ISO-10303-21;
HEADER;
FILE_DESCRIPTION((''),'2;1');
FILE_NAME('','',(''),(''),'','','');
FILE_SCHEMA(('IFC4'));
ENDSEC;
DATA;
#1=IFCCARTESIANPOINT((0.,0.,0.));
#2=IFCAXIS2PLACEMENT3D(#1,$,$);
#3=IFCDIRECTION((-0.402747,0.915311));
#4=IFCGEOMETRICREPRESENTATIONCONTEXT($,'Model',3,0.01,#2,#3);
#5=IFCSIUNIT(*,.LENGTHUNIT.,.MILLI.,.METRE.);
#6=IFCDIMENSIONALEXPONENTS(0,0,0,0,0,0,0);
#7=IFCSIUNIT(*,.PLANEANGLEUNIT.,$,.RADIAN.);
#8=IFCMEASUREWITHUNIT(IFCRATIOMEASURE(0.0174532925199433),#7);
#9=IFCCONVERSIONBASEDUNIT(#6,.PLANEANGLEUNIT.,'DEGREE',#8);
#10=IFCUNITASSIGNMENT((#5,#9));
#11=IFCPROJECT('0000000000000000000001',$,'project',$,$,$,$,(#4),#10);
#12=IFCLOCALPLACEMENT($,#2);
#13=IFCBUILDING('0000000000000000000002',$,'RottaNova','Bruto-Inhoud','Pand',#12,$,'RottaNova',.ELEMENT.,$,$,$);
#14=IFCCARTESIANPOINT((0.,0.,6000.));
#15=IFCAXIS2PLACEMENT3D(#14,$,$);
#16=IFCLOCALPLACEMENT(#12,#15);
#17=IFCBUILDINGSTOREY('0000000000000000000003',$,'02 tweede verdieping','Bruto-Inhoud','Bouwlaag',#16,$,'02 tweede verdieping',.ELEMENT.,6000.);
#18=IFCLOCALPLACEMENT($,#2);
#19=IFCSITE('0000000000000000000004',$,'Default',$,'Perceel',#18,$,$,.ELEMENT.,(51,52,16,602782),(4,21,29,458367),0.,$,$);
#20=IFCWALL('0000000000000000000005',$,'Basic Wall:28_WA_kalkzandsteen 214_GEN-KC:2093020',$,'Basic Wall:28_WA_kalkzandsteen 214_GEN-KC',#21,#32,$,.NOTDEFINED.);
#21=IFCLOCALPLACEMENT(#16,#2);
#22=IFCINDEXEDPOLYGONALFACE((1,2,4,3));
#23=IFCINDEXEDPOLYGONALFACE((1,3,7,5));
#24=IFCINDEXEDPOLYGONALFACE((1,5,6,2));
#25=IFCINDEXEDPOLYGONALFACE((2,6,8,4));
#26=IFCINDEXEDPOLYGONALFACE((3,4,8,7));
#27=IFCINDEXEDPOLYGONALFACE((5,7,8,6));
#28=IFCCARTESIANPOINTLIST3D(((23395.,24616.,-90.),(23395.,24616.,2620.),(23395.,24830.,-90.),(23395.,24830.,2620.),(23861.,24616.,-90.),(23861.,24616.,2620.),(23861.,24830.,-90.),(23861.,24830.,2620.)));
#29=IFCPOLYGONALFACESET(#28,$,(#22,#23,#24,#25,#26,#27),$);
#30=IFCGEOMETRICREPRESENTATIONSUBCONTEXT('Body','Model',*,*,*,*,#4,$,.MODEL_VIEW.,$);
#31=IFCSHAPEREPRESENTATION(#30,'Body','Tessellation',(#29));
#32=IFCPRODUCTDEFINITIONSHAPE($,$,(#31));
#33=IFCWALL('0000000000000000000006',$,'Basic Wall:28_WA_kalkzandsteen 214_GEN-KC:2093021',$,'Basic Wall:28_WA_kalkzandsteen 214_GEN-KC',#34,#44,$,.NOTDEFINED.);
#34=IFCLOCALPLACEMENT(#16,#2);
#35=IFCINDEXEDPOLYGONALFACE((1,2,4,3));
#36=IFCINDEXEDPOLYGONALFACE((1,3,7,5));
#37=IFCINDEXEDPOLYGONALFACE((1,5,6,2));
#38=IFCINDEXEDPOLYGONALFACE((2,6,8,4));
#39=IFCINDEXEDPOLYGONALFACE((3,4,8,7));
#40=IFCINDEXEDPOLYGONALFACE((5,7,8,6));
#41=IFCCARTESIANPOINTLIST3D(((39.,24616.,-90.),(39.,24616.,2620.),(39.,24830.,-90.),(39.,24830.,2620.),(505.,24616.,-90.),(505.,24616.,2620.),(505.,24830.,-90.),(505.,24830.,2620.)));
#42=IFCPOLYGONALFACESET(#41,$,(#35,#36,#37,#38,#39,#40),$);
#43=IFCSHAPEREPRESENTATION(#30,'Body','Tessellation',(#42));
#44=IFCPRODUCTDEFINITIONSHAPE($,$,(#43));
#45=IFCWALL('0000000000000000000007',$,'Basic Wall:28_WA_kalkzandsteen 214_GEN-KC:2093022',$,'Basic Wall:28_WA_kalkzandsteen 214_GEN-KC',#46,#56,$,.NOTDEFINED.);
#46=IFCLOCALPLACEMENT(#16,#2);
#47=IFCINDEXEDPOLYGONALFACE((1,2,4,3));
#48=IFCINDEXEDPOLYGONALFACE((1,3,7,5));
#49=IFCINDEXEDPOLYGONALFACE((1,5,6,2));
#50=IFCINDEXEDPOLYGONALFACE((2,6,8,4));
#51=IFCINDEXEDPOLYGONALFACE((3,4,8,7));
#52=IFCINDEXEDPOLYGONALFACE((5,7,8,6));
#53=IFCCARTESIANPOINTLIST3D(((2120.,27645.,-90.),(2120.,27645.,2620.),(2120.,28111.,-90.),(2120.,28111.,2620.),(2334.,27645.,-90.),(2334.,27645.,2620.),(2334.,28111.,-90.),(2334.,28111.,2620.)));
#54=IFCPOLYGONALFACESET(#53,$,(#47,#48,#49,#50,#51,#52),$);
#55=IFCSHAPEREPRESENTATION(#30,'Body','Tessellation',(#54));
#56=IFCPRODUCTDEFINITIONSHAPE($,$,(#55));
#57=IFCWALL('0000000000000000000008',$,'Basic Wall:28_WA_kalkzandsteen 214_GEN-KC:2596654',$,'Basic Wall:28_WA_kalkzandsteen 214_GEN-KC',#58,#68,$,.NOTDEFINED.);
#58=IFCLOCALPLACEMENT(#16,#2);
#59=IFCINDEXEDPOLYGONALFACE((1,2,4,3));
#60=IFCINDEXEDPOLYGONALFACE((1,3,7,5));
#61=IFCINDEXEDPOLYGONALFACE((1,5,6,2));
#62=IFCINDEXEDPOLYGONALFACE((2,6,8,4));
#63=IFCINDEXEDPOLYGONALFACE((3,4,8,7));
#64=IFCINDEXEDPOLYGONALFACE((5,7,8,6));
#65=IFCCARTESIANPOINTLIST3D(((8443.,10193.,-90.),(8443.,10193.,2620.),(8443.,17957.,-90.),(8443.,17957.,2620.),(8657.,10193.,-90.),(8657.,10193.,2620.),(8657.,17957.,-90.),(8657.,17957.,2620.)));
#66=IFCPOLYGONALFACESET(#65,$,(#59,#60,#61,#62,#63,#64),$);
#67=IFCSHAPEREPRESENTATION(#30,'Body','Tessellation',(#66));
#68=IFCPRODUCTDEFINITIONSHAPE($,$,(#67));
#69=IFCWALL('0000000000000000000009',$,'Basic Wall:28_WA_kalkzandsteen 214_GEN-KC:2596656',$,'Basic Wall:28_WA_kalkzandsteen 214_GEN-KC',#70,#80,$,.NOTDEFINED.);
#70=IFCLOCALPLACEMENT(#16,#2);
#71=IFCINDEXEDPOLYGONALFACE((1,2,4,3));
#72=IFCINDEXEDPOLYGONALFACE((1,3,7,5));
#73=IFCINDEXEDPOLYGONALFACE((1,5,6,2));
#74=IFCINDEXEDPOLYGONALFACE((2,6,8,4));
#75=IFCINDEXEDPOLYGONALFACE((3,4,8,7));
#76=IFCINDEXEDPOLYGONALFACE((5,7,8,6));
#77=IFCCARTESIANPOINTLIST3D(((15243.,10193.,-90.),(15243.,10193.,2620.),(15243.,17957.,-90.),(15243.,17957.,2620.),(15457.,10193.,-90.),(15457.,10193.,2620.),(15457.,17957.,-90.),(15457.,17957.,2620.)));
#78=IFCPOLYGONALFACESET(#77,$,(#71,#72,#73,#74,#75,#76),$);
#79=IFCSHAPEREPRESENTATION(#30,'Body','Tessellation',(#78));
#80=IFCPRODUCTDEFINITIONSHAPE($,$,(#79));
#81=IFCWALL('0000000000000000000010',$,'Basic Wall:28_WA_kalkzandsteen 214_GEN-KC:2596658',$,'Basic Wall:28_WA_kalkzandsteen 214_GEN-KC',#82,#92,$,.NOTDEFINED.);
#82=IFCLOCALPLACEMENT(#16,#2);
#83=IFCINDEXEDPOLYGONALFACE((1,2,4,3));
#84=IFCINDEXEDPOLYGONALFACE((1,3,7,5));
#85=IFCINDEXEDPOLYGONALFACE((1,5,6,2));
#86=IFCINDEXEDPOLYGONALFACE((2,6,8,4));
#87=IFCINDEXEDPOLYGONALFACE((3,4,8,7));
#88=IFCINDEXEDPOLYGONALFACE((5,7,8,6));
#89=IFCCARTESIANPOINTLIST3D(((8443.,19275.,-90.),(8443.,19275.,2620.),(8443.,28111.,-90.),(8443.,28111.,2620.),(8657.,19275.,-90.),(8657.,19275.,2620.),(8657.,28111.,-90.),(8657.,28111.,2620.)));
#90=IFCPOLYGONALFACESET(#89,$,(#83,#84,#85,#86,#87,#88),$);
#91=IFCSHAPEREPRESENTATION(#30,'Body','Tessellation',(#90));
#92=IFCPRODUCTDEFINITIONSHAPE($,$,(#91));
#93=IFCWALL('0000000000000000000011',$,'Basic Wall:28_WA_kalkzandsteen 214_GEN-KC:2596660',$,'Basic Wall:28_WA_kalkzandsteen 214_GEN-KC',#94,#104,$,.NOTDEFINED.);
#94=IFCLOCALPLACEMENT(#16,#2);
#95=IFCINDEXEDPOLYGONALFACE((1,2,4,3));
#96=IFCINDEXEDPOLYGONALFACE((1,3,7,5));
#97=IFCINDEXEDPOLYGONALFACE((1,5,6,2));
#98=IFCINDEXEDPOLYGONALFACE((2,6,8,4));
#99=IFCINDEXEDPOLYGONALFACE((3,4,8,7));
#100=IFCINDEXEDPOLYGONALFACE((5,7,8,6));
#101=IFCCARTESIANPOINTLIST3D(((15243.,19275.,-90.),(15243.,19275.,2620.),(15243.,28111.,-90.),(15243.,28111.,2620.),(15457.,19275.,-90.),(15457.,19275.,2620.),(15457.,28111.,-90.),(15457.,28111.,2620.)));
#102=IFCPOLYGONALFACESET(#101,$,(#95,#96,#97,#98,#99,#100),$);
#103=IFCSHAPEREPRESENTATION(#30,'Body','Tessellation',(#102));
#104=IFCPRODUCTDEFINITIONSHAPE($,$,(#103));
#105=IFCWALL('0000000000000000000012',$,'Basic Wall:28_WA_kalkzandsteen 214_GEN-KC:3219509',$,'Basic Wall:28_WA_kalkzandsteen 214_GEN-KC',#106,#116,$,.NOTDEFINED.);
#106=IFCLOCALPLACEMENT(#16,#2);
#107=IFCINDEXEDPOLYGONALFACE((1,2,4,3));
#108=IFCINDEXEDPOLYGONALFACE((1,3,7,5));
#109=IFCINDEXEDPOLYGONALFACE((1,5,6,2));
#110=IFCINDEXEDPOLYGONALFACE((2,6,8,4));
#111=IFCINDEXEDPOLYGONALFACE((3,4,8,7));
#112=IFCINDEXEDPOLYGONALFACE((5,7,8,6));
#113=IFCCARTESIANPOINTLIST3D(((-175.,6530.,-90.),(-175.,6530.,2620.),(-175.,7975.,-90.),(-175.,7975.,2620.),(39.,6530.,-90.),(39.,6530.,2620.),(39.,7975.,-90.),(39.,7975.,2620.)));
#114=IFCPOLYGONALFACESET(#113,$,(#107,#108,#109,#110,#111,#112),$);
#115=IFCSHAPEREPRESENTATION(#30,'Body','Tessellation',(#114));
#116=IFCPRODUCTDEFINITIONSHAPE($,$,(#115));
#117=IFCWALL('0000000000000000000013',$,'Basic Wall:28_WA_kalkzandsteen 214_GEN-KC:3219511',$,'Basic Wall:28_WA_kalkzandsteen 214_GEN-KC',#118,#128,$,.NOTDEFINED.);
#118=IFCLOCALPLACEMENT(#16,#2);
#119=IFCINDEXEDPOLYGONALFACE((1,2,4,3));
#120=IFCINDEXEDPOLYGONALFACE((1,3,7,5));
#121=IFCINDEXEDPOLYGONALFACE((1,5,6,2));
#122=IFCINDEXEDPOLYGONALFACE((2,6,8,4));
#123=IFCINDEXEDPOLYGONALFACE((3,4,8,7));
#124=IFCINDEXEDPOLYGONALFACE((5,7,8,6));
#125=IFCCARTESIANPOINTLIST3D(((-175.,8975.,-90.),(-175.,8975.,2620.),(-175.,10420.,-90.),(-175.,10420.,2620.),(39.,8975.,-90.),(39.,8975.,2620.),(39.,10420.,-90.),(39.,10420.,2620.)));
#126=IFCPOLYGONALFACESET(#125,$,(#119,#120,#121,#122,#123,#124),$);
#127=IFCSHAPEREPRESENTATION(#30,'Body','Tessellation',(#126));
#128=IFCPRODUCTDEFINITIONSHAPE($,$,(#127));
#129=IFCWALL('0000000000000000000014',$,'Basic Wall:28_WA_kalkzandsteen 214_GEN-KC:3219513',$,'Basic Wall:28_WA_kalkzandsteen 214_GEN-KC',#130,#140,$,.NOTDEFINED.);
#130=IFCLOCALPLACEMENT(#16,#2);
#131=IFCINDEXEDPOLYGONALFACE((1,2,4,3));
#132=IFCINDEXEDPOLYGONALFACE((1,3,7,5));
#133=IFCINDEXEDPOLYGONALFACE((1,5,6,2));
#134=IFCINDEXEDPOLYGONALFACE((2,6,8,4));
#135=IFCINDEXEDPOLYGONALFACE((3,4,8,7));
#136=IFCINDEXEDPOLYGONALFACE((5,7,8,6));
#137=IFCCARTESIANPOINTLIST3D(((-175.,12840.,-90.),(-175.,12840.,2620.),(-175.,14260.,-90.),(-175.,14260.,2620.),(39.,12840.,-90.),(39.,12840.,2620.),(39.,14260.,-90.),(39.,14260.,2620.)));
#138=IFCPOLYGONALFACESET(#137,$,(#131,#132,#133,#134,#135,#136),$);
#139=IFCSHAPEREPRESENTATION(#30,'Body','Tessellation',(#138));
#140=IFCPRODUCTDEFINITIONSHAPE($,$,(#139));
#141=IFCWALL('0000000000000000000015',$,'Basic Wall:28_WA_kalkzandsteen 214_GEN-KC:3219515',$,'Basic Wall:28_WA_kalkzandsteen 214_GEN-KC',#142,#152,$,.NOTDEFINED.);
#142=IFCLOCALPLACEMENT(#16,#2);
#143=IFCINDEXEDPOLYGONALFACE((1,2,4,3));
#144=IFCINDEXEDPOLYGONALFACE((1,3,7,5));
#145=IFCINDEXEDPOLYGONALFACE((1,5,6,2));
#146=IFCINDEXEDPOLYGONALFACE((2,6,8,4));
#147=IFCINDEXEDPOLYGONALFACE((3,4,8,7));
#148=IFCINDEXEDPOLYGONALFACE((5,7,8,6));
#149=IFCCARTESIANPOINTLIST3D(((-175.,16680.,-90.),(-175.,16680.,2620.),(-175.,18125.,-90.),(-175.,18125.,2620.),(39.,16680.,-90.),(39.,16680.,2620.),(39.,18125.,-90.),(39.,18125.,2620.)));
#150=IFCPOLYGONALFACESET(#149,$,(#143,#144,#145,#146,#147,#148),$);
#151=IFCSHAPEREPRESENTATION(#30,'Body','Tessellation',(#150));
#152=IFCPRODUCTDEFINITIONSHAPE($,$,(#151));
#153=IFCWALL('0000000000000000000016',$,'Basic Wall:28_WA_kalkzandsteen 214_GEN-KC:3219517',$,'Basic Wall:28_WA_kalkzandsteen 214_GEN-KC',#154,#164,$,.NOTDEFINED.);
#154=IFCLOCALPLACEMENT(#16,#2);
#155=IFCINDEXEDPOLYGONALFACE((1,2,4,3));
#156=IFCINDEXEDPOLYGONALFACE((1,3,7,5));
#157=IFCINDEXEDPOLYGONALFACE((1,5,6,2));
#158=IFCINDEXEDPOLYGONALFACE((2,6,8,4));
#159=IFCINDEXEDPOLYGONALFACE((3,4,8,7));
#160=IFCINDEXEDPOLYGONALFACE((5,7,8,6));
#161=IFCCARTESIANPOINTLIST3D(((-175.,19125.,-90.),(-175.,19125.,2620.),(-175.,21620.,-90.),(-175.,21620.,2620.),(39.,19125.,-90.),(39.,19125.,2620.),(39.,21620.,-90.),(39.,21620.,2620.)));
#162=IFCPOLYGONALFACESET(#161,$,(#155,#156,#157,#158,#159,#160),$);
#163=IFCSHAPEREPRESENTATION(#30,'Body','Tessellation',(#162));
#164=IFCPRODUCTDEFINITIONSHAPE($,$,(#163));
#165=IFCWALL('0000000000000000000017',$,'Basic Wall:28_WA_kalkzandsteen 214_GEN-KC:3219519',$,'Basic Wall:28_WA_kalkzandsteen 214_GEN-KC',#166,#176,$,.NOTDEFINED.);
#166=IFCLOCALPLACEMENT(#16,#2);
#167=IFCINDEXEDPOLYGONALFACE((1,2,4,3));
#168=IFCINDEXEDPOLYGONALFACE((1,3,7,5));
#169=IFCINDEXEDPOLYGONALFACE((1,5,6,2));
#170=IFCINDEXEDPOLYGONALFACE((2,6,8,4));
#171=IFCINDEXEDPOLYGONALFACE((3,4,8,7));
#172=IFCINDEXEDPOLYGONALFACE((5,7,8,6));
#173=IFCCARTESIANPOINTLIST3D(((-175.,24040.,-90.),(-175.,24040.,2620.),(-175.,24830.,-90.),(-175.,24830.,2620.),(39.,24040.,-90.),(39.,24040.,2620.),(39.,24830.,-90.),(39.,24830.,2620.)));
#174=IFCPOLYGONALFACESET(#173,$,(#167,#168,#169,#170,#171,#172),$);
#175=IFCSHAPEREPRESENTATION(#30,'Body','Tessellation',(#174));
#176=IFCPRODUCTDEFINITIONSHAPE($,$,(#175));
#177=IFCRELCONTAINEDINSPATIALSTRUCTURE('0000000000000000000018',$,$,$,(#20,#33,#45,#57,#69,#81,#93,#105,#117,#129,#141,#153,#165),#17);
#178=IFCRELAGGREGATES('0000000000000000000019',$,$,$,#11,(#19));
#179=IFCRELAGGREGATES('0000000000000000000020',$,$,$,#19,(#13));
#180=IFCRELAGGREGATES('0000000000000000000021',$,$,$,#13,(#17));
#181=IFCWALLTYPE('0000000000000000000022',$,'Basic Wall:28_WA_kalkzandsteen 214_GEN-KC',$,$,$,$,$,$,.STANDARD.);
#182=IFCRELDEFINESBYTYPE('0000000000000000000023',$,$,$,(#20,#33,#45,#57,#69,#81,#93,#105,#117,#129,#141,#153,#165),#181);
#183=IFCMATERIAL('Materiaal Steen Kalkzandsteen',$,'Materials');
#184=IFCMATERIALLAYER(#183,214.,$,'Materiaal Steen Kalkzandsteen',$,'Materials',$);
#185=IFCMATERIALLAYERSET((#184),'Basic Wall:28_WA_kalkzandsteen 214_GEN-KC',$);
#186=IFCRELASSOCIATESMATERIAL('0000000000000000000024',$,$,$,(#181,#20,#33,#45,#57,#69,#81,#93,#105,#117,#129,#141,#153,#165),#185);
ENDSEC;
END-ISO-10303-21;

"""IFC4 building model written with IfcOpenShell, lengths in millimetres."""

from ifc_helpers import new_model, entity, si_unit, converted_unit, direction, frame, frame_2d, origin, place, context, subcontext, project, spatial, rectangle, extrude, material, layer, layer_set, type_object, element, save


model = new_model("IFC4")

# Units and contexts
model_context = context("Model", 3, precision=0.01, world=origin(), true_north=direction((-0.402747, 0.915311)))
body_context = subcontext(model_context, "Body", "Model", "MODEL_VIEW")
ifc_project = project(units=[si_unit("LENGTHUNIT", "METRE", prefix="MILLI"), converted_unit("PLANEANGLEUNIT", "DEGREE", entity("IfcRatioMeasure", 0.0174532925199433), si_unit("PLANEANGLEUNIT", "RADIAN"), dimensions=[0, 0, 0, 0, 0, 0, 0])], contexts=[model_context])

# Site, building, storey
site_placement = place(None, origin())
site = spatial("IfcSite", under=ifc_project, at=site_placement, Name="Default", ObjectType="Perceel", CompositionType="ELEMENT", RefLatitude=(51, 52, 16, 602782), RefLongitude=(4, 21, 29, 458367), RefElevation=0.0)
building_placement = place(None, origin())
building = spatial("IfcBuilding", under=site, at=building_placement, Name="RottaNova", Description="Bruto-Inhoud", ObjectType="Pand", LongName="RottaNova", CompositionType="ELEMENT")
storey_placement = place(building_placement, frame((0.0, 0.0, 6000.0)))
storey = spatial("IfcBuildingStorey", under=building, at=storey_placement, Name="02 tweede verdieping", Description="Bruto-Inhoud", ObjectType="Bouwlaag", LongName="02 tweede verdieping", CompositionType="ELEMENT", Elevation=6000.0)

# Walls
ifc_material_1 = material(Name="Materiaal Steen Kalkzandsteen", Category="Materials")
ifc_layer_1 = layer(ifc_material_1, 214.0, Name="Materiaal Steen Kalkzandsteen", Category="Materials")
ifc_layer_set_1 = layer_set([ifc_layer_1], Name="Basic Wall:28_WA_kalkzandsteen 214_GEN-KC")
wall_type_1 = type_object("IfcWallType", Name="Basic Wall:28_WA_kalkzandsteen 214_GEN-KC", PredefinedType="STANDARD", material=ifc_layer_set_1)
wall_1_placement = place(storey_placement, frame((23395.0, 24723.0, -90.0)))
element("IfcWall", 1, at=wall_1_placement, inside=storey, type_object=wall_type_1, material=ifc_layer_set_1, Name="Basic Wall:28_WA_kalkzandsteen 214_GEN-KC:2093020", ObjectType="Basic Wall:28_WA_kalkzandsteen 214_GEN-KC", PredefinedType="NOTDEFINED", context=body_context, shape_type="SweptSolid", body=[
    extrude(rectangle(XDim=466.0, YDim=214.0, at=frame_2d((233.0, 0.0), x_axis=(-1.0, 0.0))), origin(), (0.0, 0.0, 1.0), 2710.0),
])
wall_2_placement = place(storey_placement, frame((39.0, 24723.0, -90.0)))
element("IfcWall", 2, at=wall_2_placement, inside=storey, type_object=wall_type_1, material=ifc_layer_set_1, Name="Basic Wall:28_WA_kalkzandsteen 214_GEN-KC:2093021", ObjectType="Basic Wall:28_WA_kalkzandsteen 214_GEN-KC", PredefinedType="NOTDEFINED", context=body_context, shape_type="SweptSolid", body=[
    extrude(rectangle(XDim=466.0, YDim=214.0, at=frame_2d((233.0, 0.0), x_axis=(-1.0, 0.0))), origin(), (0.0, 0.0, 1.0), 2710.0),
])
wall_3_placement = place(storey_placement, frame((2227.0, 28111.0, -90.0), z_axis=(0.0, 0.0, 1.0), x_axis=(0.0, -1.0, 0.0)))
element("IfcWall", 3, at=wall_3_placement, inside=storey, type_object=wall_type_1, material=ifc_layer_set_1, Name="Basic Wall:28_WA_kalkzandsteen 214_GEN-KC:2093022", ObjectType="Basic Wall:28_WA_kalkzandsteen 214_GEN-KC", PredefinedType="NOTDEFINED", context=body_context, shape_type="SweptSolid", body=[
    extrude(rectangle(XDim=466.0, YDim=214.0, at=frame_2d((233.0, 0.0), x_axis=(-1.0, 0.0))), origin(), (0.0, 0.0, 1.0), 2710.0),
])
wall_4_placement = place(storey_placement, frame((8550.0, 10193.0, -90.0), z_axis=(0.0, 0.0, 1.0), x_axis=(0.0, 1.0, 0.0)))
element("IfcWall", 4, at=wall_4_placement, inside=storey, type_object=wall_type_1, material=ifc_layer_set_1, Name="Basic Wall:28_WA_kalkzandsteen 214_GEN-KC:2596654", ObjectType="Basic Wall:28_WA_kalkzandsteen 214_GEN-KC", PredefinedType="NOTDEFINED", context=body_context, shape_type="SweptSolid", body=[
    extrude(rectangle(XDim=7764.0, YDim=214.0, at=frame_2d((3882.0, 0.0), x_axis=(1.0, 0.0))), origin(), (0.0, 0.0, 1.0), 2710.0),
])
wall_5_placement = place(storey_placement, frame((15350.0, 10193.0, -90.0), z_axis=(0.0, 0.0, 1.0), x_axis=(0.0, 1.0, 0.0)))
element("IfcWall", 5, at=wall_5_placement, inside=storey, type_object=wall_type_1, material=ifc_layer_set_1, Name="Basic Wall:28_WA_kalkzandsteen 214_GEN-KC:2596656", ObjectType="Basic Wall:28_WA_kalkzandsteen 214_GEN-KC", PredefinedType="NOTDEFINED", context=body_context, shape_type="SweptSolid", body=[
    extrude(rectangle(XDim=7764.0, YDim=214.0, at=frame_2d((3882.0, 0.0), x_axis=(1.0, 0.0))), origin(), (0.0, 0.0, 1.0), 2710.0),
])
wall_6_placement = place(storey_placement, frame((8550.0, 19275.0, -90.0), z_axis=(0.0, 0.0, 1.0), x_axis=(0.0, 1.0, 0.0)))
element("IfcWall", 6, at=wall_6_placement, inside=storey, type_object=wall_type_1, material=ifc_layer_set_1, Name="Basic Wall:28_WA_kalkzandsteen 214_GEN-KC:2596658", ObjectType="Basic Wall:28_WA_kalkzandsteen 214_GEN-KC", PredefinedType="NOTDEFINED", context=body_context, shape_type="SweptSolid", body=[
    extrude(rectangle(XDim=8836.0, YDim=214.0, at=frame_2d((0.0, 0.0), x_axis=(1.0, 0.0))), frame((4418.0, 0.0, 0.0), z_axis=(0.0, 0.0, 1.0), x_axis=(-1.0, 0.0, 0.0)), (0.0, 0.0, 1.0), 2710.0),
])
wall_7_placement = place(storey_placement, frame((15350.0, 19275.0, -90.0), z_axis=(0.0, 0.0, 1.0), x_axis=(0.0, 1.0, 0.0)))
element("IfcWall", 7, at=wall_7_placement, inside=storey, type_object=wall_type_1, material=ifc_layer_set_1, Name="Basic Wall:28_WA_kalkzandsteen 214_GEN-KC:2596660", ObjectType="Basic Wall:28_WA_kalkzandsteen 214_GEN-KC", PredefinedType="NOTDEFINED", context=body_context, shape_type="SweptSolid", body=[
    extrude(rectangle(XDim=8836.0, YDim=214.0, at=frame_2d((0.0, 0.0), x_axis=(1.0, 0.0))), frame((4418.0, 0.0, 0.0), z_axis=(0.0, 0.0, 1.0), x_axis=(-1.0, 0.0, 0.0)), (0.0, 0.0, 1.0), 2710.0),
])
wall_8_placement = place(storey_placement, frame((-68.0, 6530.0, -90.0), z_axis=(0.0, 0.0, 1.0), x_axis=(0.0, 1.0, 0.0)))
element("IfcWall", 8, at=wall_8_placement, inside=storey, type_object=wall_type_1, material=ifc_layer_set_1, Name="Basic Wall:28_WA_kalkzandsteen 214_GEN-KC:3219509", ObjectType="Basic Wall:28_WA_kalkzandsteen 214_GEN-KC", PredefinedType="NOTDEFINED", context=body_context, shape_type="SweptSolid", body=[
    extrude(rectangle(XDim=1445.0, YDim=214.0, at=frame_2d((722.5, 0.0), x_axis=(-1.0, 0.0))), origin(), (0.0, 0.0, 1.0), 2710.0),
])
wall_9_placement = place(storey_placement, frame((-68.0, 8975.0, -90.0), z_axis=(0.0, 0.0, 1.0), x_axis=(0.0, 1.0, 0.0)))
element("IfcWall", 9, at=wall_9_placement, inside=storey, type_object=wall_type_1, material=ifc_layer_set_1, Name="Basic Wall:28_WA_kalkzandsteen 214_GEN-KC:3219511", ObjectType="Basic Wall:28_WA_kalkzandsteen 214_GEN-KC", PredefinedType="NOTDEFINED", context=body_context, shape_type="SweptSolid", body=[
    extrude(rectangle(XDim=1445.0, YDim=214.0, at=frame_2d((722.5, 0.0), x_axis=(-1.0, 0.0))), origin(), (0.0, 0.0, 1.0), 2710.0),
])
wall_10_placement = place(storey_placement, frame((-68.0, 12840.0, -90.0), z_axis=(0.0, 0.0, 1.0), x_axis=(0.0, 1.0, 0.0)))
element("IfcWall", 10, at=wall_10_placement, inside=storey, type_object=wall_type_1, material=ifc_layer_set_1, Name="Basic Wall:28_WA_kalkzandsteen 214_GEN-KC:3219513", ObjectType="Basic Wall:28_WA_kalkzandsteen 214_GEN-KC", PredefinedType="NOTDEFINED", context=body_context, shape_type="SweptSolid", body=[
    extrude(rectangle(XDim=1420.0, YDim=214.0, at=frame_2d((710.0, 0.0), x_axis=(-1.0, 0.0))), origin(), (0.0, 0.0, 1.0), 2710.0),
])
wall_11_placement = place(storey_placement, frame((-68.0, 16680.0, -90.0), z_axis=(0.0, 0.0, 1.0), x_axis=(0.0, 1.0, 0.0)))
element("IfcWall", 11, at=wall_11_placement, inside=storey, type_object=wall_type_1, material=ifc_layer_set_1, Name="Basic Wall:28_WA_kalkzandsteen 214_GEN-KC:3219515", ObjectType="Basic Wall:28_WA_kalkzandsteen 214_GEN-KC", PredefinedType="NOTDEFINED", context=body_context, shape_type="SweptSolid", body=[
    extrude(rectangle(XDim=1445.0, YDim=214.0, at=frame_2d((722.5, 0.0), x_axis=(-1.0, 0.0))), origin(), (0.0, 0.0, 1.0), 2710.0),
])
wall_12_placement = place(storey_placement, frame((-68.0, 19125.0, -90.0), z_axis=(0.0, 0.0, 1.0), x_axis=(0.0, 1.0, 0.0)))
element("IfcWall", 12, at=wall_12_placement, inside=storey, type_object=wall_type_1, material=ifc_layer_set_1, Name="Basic Wall:28_WA_kalkzandsteen 214_GEN-KC:3219517", ObjectType="Basic Wall:28_WA_kalkzandsteen 214_GEN-KC", PredefinedType="NOTDEFINED", context=body_context, shape_type="SweptSolid", body=[
    extrude(rectangle(XDim=2495.0, YDim=214.0, at=frame_2d((1247.5, 0.0), x_axis=(-1.0, 0.0))), origin(), (0.0, 0.0, 1.0), 2710.0),
])
wall_13_placement = place(storey_placement, frame((-68.0, 24040.0, -90.0), z_axis=(0.0, 0.0, 1.0), x_axis=(0.0, 1.0, 0.0)))
element("IfcWall", 13, at=wall_13_placement, inside=storey, type_object=wall_type_1, material=ifc_layer_set_1, Name="Basic Wall:28_WA_kalkzandsteen 214_GEN-KC:3219519", ObjectType="Basic Wall:28_WA_kalkzandsteen 214_GEN-KC", PredefinedType="NOTDEFINED", context=body_context, shape_type="SweptSolid", body=[
    extrude(rectangle(XDim=790.0, YDim=214.0, at=frame_2d((395.0, 0.0), x_axis=(-1.0, 0.0))), origin(), (0.0, 0.0, 1.0), 2710.0),
])

save(model, "model.ifc")
